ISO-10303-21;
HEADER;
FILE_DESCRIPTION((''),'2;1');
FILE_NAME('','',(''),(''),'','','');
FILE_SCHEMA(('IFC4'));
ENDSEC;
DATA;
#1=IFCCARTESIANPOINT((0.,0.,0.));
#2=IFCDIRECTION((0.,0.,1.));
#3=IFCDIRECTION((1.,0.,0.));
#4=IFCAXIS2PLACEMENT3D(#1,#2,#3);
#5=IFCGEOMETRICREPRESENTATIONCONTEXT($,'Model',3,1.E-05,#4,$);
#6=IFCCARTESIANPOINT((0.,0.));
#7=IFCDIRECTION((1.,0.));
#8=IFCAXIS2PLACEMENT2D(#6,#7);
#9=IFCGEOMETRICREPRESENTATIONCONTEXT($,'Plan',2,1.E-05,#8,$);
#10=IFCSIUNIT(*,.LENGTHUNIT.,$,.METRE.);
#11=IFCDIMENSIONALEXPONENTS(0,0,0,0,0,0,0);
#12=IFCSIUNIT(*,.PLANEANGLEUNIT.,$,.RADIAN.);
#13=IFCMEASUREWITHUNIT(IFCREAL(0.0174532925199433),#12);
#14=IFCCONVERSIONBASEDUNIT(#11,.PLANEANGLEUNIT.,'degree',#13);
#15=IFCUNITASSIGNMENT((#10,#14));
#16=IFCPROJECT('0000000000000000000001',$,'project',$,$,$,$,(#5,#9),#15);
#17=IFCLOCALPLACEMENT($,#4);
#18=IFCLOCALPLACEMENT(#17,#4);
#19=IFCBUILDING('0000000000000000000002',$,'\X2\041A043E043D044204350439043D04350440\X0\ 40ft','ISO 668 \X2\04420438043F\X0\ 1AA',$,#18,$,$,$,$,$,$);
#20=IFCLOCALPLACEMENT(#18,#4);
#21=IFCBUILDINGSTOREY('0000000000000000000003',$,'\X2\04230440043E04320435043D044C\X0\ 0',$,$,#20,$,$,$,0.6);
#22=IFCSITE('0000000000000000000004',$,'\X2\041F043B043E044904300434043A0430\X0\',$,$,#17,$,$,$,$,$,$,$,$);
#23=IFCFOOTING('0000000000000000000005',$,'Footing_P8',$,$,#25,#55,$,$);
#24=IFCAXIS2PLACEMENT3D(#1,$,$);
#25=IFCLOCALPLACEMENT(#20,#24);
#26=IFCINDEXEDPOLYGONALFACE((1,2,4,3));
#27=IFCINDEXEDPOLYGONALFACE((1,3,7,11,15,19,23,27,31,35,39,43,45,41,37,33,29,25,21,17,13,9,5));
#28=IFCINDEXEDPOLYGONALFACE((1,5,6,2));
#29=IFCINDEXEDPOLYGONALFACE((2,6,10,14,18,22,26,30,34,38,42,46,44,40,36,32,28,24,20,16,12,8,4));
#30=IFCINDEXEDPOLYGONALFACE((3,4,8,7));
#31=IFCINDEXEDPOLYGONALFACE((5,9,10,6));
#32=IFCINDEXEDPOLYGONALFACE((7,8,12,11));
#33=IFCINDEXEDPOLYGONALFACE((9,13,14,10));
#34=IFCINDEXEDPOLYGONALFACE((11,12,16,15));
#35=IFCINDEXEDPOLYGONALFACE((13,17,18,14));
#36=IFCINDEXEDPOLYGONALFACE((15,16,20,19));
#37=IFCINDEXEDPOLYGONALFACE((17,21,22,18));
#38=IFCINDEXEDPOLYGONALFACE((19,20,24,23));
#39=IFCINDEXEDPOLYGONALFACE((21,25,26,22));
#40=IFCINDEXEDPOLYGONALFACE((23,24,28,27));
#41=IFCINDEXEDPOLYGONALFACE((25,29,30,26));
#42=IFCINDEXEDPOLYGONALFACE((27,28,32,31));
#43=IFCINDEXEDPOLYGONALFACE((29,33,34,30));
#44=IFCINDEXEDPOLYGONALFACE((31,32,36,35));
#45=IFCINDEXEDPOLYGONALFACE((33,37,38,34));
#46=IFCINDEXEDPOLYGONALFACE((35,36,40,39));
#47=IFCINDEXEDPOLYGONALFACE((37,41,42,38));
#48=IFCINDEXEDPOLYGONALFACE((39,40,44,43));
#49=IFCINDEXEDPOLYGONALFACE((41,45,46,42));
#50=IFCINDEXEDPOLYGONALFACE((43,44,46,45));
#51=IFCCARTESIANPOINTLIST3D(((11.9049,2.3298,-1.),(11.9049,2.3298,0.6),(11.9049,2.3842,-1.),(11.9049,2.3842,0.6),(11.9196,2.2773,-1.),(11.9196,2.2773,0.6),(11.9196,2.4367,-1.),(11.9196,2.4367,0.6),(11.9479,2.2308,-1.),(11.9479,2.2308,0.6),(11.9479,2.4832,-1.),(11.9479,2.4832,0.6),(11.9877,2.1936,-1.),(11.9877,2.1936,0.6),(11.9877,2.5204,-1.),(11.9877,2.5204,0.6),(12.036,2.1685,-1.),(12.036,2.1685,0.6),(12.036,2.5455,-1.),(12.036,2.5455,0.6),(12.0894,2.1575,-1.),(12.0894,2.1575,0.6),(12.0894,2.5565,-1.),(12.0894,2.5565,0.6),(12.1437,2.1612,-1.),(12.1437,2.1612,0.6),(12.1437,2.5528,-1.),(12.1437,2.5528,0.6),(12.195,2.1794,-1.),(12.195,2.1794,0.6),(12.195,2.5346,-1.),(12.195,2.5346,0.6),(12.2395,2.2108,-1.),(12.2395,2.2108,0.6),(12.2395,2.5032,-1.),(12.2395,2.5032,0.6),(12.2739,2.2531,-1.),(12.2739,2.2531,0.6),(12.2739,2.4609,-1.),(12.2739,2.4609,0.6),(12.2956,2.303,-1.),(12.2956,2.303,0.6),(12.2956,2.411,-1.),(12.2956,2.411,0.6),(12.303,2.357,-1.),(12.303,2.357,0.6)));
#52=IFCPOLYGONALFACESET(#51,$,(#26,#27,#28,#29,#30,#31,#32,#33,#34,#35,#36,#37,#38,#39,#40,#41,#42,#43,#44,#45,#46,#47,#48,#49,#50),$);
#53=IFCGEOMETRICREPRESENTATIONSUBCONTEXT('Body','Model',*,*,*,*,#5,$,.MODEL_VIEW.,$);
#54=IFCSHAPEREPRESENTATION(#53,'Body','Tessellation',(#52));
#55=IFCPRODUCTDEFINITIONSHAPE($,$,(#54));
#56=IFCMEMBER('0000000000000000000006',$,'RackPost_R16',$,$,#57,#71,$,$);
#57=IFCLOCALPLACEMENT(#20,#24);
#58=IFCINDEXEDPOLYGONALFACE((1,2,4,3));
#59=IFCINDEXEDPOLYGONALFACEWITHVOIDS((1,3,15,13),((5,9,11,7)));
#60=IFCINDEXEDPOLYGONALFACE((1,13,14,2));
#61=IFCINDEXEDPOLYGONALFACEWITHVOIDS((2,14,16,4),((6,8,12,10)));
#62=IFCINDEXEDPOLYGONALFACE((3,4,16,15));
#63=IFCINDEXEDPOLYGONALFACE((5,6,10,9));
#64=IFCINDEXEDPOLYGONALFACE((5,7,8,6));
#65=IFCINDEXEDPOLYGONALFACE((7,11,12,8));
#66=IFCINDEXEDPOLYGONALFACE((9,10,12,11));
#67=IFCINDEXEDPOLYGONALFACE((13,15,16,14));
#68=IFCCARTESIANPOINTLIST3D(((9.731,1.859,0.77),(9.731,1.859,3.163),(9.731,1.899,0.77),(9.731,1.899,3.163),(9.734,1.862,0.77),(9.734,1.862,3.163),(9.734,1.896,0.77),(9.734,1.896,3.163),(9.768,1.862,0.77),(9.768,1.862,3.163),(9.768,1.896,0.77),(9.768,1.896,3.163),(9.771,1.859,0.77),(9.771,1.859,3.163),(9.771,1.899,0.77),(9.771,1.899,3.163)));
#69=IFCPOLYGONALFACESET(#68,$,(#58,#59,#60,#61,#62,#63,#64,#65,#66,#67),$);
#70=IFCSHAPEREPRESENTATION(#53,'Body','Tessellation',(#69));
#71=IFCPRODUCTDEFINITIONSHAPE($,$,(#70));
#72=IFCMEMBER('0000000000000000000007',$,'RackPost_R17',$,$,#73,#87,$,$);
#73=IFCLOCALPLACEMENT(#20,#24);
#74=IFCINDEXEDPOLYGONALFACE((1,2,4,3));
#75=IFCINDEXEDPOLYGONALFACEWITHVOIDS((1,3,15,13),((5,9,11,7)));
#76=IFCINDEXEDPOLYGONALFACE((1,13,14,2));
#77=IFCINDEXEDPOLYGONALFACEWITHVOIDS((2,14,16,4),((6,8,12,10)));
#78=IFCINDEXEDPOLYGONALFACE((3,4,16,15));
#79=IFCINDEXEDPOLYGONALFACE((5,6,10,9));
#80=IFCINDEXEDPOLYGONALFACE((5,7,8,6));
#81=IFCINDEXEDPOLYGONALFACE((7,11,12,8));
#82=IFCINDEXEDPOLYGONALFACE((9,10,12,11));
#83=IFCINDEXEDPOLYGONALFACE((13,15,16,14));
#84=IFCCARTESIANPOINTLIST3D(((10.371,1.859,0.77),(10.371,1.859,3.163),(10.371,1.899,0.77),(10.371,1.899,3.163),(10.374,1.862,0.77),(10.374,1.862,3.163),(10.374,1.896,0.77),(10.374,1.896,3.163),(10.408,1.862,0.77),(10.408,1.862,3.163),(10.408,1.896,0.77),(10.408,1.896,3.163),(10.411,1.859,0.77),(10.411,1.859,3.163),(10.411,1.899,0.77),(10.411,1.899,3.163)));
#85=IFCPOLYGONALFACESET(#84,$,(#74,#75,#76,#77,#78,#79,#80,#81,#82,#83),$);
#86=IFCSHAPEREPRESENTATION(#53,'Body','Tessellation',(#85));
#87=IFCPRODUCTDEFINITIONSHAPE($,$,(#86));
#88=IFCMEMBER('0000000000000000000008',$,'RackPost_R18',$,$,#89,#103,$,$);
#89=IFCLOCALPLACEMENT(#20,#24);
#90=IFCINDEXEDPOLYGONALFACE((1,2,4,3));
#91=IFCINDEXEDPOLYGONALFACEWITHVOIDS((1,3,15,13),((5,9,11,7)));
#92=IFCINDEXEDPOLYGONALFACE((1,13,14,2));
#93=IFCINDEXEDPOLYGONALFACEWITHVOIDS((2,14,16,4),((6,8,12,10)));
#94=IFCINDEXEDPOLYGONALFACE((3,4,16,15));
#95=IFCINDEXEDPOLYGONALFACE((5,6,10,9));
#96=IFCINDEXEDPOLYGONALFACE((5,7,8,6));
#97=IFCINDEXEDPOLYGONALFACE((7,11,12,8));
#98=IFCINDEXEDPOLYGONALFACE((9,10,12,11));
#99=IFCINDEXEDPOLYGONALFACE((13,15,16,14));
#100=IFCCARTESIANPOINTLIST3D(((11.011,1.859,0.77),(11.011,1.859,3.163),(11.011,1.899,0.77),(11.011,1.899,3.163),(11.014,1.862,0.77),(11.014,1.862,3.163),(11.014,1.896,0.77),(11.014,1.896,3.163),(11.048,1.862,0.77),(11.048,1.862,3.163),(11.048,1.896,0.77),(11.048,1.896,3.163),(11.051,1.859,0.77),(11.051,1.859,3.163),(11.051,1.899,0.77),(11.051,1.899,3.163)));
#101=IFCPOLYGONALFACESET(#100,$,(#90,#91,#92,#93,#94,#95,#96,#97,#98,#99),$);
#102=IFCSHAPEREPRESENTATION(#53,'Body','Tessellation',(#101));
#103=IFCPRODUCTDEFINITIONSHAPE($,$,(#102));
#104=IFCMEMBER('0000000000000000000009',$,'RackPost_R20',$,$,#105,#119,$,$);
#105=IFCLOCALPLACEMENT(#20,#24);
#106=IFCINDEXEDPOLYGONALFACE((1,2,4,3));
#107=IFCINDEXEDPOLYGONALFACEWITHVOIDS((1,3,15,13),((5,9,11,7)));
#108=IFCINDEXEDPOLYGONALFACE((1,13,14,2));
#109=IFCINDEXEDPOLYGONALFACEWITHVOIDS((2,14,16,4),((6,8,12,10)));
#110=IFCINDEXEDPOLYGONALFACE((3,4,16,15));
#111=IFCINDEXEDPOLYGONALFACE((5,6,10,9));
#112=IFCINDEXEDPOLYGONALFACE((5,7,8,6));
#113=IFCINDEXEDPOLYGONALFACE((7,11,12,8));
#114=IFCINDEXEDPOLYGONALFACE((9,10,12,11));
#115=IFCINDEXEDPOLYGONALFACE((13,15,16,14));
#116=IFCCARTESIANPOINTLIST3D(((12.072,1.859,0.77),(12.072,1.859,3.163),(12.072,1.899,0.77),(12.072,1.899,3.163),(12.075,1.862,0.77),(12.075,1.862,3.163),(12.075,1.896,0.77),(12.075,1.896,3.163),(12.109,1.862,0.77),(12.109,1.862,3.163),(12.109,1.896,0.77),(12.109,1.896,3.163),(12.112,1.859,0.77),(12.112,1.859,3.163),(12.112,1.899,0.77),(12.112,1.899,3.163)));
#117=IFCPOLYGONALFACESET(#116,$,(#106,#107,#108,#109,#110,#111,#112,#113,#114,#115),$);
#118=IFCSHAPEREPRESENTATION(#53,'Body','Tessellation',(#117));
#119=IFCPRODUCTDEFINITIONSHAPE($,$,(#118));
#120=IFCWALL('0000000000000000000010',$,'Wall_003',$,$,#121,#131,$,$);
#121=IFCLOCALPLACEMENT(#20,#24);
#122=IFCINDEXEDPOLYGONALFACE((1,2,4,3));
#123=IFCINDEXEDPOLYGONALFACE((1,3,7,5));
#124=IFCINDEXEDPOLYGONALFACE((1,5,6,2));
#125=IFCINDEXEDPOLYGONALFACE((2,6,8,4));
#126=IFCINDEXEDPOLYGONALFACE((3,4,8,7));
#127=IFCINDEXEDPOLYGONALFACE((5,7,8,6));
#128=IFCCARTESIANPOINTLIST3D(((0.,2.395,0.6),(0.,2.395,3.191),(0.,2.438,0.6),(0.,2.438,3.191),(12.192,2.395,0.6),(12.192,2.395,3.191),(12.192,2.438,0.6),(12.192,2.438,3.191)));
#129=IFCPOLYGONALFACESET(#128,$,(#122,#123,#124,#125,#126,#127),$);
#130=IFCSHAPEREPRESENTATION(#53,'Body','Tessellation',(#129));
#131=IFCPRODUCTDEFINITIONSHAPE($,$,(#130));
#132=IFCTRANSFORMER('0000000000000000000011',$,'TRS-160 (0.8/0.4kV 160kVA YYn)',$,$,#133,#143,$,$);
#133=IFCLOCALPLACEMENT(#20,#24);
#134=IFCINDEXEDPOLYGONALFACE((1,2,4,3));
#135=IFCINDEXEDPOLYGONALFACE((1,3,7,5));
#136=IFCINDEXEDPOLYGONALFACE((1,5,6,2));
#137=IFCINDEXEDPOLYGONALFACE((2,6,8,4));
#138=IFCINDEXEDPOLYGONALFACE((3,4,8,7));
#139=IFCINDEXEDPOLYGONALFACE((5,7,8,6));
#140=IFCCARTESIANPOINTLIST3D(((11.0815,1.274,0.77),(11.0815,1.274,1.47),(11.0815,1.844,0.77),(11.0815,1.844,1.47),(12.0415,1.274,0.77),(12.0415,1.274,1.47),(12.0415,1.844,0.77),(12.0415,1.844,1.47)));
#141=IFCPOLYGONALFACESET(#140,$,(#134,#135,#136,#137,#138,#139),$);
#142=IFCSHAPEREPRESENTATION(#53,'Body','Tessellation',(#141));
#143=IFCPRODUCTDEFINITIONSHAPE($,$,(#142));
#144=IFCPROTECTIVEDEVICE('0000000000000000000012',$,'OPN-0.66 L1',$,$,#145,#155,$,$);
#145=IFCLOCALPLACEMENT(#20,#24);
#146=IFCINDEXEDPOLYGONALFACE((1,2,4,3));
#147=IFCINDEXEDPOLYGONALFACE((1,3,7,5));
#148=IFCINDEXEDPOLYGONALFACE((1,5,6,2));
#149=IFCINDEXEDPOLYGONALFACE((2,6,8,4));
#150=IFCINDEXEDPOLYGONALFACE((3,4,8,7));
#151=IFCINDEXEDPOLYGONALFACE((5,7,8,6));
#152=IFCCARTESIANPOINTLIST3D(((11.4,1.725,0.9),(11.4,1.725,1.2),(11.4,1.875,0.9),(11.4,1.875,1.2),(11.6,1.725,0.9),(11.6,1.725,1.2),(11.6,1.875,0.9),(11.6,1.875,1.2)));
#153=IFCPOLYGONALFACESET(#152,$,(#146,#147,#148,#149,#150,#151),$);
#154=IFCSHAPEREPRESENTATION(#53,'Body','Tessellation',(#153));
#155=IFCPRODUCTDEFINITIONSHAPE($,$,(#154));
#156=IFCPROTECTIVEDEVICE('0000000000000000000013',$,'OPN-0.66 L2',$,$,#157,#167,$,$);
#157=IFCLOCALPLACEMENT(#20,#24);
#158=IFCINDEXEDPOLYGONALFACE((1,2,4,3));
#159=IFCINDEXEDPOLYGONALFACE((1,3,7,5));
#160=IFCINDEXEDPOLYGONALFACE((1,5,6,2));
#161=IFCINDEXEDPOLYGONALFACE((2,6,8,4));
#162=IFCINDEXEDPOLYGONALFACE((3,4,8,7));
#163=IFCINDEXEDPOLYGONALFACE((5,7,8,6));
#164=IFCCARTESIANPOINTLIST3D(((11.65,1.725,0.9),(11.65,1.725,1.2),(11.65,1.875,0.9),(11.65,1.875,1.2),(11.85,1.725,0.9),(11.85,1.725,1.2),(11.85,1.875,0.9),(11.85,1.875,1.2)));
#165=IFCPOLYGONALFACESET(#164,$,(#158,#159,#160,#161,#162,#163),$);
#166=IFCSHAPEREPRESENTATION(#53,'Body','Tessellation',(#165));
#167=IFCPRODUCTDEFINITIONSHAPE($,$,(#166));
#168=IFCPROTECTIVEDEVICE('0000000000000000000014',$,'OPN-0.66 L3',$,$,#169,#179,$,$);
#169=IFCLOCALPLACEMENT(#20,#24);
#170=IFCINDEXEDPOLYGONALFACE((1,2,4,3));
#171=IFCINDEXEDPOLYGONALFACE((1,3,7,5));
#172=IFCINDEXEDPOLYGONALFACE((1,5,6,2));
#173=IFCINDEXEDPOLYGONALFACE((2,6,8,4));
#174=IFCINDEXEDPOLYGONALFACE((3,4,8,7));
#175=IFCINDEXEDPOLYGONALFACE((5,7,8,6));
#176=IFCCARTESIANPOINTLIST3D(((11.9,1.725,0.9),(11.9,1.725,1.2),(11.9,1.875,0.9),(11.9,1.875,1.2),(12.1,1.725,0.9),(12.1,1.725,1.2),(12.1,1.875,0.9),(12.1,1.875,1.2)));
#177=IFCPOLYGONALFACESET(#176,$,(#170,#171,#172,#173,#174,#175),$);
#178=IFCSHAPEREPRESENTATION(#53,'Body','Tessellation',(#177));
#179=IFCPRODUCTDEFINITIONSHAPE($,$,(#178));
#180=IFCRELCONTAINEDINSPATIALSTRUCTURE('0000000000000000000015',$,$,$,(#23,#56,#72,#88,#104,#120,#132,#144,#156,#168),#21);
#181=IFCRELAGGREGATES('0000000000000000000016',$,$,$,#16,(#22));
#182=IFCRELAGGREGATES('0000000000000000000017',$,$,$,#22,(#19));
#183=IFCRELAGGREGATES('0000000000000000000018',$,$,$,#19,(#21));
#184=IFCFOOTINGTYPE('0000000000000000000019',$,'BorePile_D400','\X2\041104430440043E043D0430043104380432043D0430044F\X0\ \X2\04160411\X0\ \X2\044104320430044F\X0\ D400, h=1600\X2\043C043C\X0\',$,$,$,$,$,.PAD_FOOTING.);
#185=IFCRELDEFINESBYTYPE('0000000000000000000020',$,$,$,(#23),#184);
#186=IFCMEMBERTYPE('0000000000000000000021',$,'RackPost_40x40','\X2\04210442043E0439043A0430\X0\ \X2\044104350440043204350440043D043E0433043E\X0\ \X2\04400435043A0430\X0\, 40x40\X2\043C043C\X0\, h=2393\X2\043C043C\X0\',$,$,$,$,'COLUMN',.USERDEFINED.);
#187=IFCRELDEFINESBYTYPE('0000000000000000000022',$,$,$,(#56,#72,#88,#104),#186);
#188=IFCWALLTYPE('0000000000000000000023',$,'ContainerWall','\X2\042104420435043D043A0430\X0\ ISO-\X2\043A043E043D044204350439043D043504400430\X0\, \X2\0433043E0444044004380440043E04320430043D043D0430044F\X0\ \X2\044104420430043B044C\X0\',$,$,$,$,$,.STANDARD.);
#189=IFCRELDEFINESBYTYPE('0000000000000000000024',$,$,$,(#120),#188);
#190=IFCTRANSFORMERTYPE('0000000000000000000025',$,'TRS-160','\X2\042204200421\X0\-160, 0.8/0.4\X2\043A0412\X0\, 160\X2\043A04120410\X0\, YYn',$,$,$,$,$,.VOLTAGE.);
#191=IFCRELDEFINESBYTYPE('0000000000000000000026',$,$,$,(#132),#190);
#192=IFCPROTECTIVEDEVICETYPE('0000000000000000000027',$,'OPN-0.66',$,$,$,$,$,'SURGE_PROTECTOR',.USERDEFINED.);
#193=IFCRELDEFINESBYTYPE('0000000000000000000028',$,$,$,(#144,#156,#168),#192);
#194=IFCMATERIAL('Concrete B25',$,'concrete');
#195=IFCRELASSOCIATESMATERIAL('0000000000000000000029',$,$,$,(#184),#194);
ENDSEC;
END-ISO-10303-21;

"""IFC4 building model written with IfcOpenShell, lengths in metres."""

from ifc_helpers import new_model, entity, si_unit, converted_unit, frame, origin_with_axes, origin_2d_with_axis, place, context, subcontext, project, spatial, indexed_curve, rectangle, hollow_rectangle, circle, outline, extrude, material, type_object, element, save


model = new_model("IFC4")

# Units and contexts
model_context = context("Model", 3, precision=1e-05, world=origin_with_axes())
plan_context = context("Plan", 2, precision=1e-05, world=origin_2d_with_axis())
body_context = subcontext(model_context, "Body", "Model", "MODEL_VIEW")
ifc_project = project(units=[si_unit("LENGTHUNIT", "METRE"), converted_unit("PLANEANGLEUNIT", "degree", entity("IfcReal", 0.0174532925199433), si_unit("PLANEANGLEUNIT", "RADIAN"), dimensions=[0, 0, 0, 0, 0, 0, 0])], contexts=[model_context, plan_context])

# Site, building, storey
site_placement = place(None, origin_with_axes())
site = spatial("IfcSite", under=ifc_project, at=site_placement, Name="Площадка")
building_placement = place(site_placement, origin_with_axes())
building = spatial("IfcBuilding", under=site, at=building_placement, Name="Контейнер 40ft", Description="ISO 668 тип 1AA")
storey_placement = place(building_placement, origin_with_axes())
storey = spatial("IfcBuildingStorey", under=building, at=storey_placement, Name="Уровень 0", Elevation=0.6)

# Footing
ifc_material = material(Name="Concrete B25", Category="concrete")
footing_type = type_object("IfcFootingType", Name="BorePile_D400", Description="Буронабивная ЖБ свая D400, h=1600мм", PredefinedType="PAD_FOOTING", material=ifc_material)
footing_placement = place(storey_placement, frame((12.103, 2.357, -1.0), z_axis=(0.0, 0.0, 1.0), x_axis=(1.0, 0.0, 0.0)))
element("IfcFooting", 1, at=footing_placement, inside=storey, type_object=footing_type, Name="Footing_P8", context=body_context, shape_type="SweptSolid", body=[
    extrude(circle(Radius=0.2), origin_with_axes(), (0.0, 0.0, 1.0), 1.6),
])

# Members
member_type = type_object("IfcMemberType", Name="RackPost_40x40", Description="Стойка серверного река, 40x40мм, h=2393мм", ElementType="COLUMN", PredefinedType="USERDEFINED")
for number, where, z_axis, x_axis, name in (
    (2, (9.751, 1.879, 0.77), (0.0, 0.0, 1.0), (1.0, 0.0, 0.0), "RackPost_R16"),
    (3, (10.391, 1.879, 0.77), (0.0, 0.0, 1.0), (1.0, 0.0, 0.0), "RackPost_R17"),
    (4, (11.031, 1.879, 0.77), (0.0, 0.0, 1.0), (1.0, 0.0, 0.0), "RackPost_R18"),
    (5, (12.092, 1.879, 0.77), (0.0, 0.0, 1.0), (1.0, 0.0, 0.0), "RackPost_R20"),
):
    element("IfcMember", number, at=place(storey_placement, frame(where, z_axis=z_axis, x_axis=x_axis)), inside=storey, type_object=member_type, Name=name, context=body_context, shape_type="SweptSolid", body=[
        extrude(hollow_rectangle(XDim=0.04, YDim=0.04, WallThickness=0.003), origin_with_axes(), (0.0, 0.0, 1.0), 2.393),
    ])

# Wall
wall_type = type_object("IfcWallType", Name="ContainerWall", Description="Стенка ISO-контейнера, гофрированная сталь", PredefinedType="STANDARD")
wall_placement = place(storey_placement, frame((12.192, 2.438, 0.6), z_axis=(0.0, 0.0, 1.0), x_axis=(-1.0, 0.0, 0.0)))
element("IfcWall", 6, at=wall_placement, inside=storey, type_object=wall_type, Name="Wall_003", context=body_context, shape_type="SweptSolid", body=[
    extrude(outline(indexed_curve([(0.0, 0.0), (0.0, 0.043), (12.192, 0.043), (12.192, 0.0), (0.0, 0.0)], self_intersect=False)), origin_with_axes(), (0.0, 0.0, 1.0), 2.591),
])

# Transformer
transformer_type = type_object("IfcTransformerType", Name="TRS-160", Description="ТРС-160, 0.8/0.4кВ, 160кВА, YYn", PredefinedType="VOLTAGE")
transformer_placement = place(storey_placement, frame((11.5615, 1.559, 0.77), z_axis=(0.0, 0.0, 1.0), x_axis=(1.0, 0.0, 0.0)))
element("IfcTransformer", 7, at=transformer_placement, inside=storey, type_object=transformer_type, Name="TRS-160 (0.8/0.4kV 160kVA YYn)", context=body_context, shape_type="SweptSolid", body=[
    extrude(rectangle(XDim=0.96, YDim=0.57), origin_with_axes(), (0.0, 0.0, 1.0), 0.7),
])

# Protective devices
protective_device_type = type_object("IfcProtectiveDeviceType", Name="OPN-0.66", ElementType="SURGE_PROTECTOR", PredefinedType="USERDEFINED")
for number, where, z_axis, x_axis, name in (
    (8, (11.5, 1.8, 0.9), (0.0, 0.0, 1.0), (1.0, 0.0, 0.0), "OPN-0.66 L1"),
    (9, (11.75, 1.8, 0.9), (0.0, 0.0, 1.0), (1.0, 0.0, 0.0), "OPN-0.66 L2"),
    (10, (12.0, 1.8, 0.9), (0.0, 0.0, 1.0), (1.0, 0.0, 0.0), "OPN-0.66 L3"),
):
    element("IfcProtectiveDevice", number, at=place(storey_placement, frame(where, z_axis=z_axis, x_axis=x_axis)), inside=storey, type_object=protective_device_type, Name=name, context=body_context, shape_type="SweptSolid", body=[
        extrude(rectangle(XDim=0.2, YDim=0.15), None, (0.0, 0.0, 1.0), 0.3),
    ])

save(model, "model.ifc")
